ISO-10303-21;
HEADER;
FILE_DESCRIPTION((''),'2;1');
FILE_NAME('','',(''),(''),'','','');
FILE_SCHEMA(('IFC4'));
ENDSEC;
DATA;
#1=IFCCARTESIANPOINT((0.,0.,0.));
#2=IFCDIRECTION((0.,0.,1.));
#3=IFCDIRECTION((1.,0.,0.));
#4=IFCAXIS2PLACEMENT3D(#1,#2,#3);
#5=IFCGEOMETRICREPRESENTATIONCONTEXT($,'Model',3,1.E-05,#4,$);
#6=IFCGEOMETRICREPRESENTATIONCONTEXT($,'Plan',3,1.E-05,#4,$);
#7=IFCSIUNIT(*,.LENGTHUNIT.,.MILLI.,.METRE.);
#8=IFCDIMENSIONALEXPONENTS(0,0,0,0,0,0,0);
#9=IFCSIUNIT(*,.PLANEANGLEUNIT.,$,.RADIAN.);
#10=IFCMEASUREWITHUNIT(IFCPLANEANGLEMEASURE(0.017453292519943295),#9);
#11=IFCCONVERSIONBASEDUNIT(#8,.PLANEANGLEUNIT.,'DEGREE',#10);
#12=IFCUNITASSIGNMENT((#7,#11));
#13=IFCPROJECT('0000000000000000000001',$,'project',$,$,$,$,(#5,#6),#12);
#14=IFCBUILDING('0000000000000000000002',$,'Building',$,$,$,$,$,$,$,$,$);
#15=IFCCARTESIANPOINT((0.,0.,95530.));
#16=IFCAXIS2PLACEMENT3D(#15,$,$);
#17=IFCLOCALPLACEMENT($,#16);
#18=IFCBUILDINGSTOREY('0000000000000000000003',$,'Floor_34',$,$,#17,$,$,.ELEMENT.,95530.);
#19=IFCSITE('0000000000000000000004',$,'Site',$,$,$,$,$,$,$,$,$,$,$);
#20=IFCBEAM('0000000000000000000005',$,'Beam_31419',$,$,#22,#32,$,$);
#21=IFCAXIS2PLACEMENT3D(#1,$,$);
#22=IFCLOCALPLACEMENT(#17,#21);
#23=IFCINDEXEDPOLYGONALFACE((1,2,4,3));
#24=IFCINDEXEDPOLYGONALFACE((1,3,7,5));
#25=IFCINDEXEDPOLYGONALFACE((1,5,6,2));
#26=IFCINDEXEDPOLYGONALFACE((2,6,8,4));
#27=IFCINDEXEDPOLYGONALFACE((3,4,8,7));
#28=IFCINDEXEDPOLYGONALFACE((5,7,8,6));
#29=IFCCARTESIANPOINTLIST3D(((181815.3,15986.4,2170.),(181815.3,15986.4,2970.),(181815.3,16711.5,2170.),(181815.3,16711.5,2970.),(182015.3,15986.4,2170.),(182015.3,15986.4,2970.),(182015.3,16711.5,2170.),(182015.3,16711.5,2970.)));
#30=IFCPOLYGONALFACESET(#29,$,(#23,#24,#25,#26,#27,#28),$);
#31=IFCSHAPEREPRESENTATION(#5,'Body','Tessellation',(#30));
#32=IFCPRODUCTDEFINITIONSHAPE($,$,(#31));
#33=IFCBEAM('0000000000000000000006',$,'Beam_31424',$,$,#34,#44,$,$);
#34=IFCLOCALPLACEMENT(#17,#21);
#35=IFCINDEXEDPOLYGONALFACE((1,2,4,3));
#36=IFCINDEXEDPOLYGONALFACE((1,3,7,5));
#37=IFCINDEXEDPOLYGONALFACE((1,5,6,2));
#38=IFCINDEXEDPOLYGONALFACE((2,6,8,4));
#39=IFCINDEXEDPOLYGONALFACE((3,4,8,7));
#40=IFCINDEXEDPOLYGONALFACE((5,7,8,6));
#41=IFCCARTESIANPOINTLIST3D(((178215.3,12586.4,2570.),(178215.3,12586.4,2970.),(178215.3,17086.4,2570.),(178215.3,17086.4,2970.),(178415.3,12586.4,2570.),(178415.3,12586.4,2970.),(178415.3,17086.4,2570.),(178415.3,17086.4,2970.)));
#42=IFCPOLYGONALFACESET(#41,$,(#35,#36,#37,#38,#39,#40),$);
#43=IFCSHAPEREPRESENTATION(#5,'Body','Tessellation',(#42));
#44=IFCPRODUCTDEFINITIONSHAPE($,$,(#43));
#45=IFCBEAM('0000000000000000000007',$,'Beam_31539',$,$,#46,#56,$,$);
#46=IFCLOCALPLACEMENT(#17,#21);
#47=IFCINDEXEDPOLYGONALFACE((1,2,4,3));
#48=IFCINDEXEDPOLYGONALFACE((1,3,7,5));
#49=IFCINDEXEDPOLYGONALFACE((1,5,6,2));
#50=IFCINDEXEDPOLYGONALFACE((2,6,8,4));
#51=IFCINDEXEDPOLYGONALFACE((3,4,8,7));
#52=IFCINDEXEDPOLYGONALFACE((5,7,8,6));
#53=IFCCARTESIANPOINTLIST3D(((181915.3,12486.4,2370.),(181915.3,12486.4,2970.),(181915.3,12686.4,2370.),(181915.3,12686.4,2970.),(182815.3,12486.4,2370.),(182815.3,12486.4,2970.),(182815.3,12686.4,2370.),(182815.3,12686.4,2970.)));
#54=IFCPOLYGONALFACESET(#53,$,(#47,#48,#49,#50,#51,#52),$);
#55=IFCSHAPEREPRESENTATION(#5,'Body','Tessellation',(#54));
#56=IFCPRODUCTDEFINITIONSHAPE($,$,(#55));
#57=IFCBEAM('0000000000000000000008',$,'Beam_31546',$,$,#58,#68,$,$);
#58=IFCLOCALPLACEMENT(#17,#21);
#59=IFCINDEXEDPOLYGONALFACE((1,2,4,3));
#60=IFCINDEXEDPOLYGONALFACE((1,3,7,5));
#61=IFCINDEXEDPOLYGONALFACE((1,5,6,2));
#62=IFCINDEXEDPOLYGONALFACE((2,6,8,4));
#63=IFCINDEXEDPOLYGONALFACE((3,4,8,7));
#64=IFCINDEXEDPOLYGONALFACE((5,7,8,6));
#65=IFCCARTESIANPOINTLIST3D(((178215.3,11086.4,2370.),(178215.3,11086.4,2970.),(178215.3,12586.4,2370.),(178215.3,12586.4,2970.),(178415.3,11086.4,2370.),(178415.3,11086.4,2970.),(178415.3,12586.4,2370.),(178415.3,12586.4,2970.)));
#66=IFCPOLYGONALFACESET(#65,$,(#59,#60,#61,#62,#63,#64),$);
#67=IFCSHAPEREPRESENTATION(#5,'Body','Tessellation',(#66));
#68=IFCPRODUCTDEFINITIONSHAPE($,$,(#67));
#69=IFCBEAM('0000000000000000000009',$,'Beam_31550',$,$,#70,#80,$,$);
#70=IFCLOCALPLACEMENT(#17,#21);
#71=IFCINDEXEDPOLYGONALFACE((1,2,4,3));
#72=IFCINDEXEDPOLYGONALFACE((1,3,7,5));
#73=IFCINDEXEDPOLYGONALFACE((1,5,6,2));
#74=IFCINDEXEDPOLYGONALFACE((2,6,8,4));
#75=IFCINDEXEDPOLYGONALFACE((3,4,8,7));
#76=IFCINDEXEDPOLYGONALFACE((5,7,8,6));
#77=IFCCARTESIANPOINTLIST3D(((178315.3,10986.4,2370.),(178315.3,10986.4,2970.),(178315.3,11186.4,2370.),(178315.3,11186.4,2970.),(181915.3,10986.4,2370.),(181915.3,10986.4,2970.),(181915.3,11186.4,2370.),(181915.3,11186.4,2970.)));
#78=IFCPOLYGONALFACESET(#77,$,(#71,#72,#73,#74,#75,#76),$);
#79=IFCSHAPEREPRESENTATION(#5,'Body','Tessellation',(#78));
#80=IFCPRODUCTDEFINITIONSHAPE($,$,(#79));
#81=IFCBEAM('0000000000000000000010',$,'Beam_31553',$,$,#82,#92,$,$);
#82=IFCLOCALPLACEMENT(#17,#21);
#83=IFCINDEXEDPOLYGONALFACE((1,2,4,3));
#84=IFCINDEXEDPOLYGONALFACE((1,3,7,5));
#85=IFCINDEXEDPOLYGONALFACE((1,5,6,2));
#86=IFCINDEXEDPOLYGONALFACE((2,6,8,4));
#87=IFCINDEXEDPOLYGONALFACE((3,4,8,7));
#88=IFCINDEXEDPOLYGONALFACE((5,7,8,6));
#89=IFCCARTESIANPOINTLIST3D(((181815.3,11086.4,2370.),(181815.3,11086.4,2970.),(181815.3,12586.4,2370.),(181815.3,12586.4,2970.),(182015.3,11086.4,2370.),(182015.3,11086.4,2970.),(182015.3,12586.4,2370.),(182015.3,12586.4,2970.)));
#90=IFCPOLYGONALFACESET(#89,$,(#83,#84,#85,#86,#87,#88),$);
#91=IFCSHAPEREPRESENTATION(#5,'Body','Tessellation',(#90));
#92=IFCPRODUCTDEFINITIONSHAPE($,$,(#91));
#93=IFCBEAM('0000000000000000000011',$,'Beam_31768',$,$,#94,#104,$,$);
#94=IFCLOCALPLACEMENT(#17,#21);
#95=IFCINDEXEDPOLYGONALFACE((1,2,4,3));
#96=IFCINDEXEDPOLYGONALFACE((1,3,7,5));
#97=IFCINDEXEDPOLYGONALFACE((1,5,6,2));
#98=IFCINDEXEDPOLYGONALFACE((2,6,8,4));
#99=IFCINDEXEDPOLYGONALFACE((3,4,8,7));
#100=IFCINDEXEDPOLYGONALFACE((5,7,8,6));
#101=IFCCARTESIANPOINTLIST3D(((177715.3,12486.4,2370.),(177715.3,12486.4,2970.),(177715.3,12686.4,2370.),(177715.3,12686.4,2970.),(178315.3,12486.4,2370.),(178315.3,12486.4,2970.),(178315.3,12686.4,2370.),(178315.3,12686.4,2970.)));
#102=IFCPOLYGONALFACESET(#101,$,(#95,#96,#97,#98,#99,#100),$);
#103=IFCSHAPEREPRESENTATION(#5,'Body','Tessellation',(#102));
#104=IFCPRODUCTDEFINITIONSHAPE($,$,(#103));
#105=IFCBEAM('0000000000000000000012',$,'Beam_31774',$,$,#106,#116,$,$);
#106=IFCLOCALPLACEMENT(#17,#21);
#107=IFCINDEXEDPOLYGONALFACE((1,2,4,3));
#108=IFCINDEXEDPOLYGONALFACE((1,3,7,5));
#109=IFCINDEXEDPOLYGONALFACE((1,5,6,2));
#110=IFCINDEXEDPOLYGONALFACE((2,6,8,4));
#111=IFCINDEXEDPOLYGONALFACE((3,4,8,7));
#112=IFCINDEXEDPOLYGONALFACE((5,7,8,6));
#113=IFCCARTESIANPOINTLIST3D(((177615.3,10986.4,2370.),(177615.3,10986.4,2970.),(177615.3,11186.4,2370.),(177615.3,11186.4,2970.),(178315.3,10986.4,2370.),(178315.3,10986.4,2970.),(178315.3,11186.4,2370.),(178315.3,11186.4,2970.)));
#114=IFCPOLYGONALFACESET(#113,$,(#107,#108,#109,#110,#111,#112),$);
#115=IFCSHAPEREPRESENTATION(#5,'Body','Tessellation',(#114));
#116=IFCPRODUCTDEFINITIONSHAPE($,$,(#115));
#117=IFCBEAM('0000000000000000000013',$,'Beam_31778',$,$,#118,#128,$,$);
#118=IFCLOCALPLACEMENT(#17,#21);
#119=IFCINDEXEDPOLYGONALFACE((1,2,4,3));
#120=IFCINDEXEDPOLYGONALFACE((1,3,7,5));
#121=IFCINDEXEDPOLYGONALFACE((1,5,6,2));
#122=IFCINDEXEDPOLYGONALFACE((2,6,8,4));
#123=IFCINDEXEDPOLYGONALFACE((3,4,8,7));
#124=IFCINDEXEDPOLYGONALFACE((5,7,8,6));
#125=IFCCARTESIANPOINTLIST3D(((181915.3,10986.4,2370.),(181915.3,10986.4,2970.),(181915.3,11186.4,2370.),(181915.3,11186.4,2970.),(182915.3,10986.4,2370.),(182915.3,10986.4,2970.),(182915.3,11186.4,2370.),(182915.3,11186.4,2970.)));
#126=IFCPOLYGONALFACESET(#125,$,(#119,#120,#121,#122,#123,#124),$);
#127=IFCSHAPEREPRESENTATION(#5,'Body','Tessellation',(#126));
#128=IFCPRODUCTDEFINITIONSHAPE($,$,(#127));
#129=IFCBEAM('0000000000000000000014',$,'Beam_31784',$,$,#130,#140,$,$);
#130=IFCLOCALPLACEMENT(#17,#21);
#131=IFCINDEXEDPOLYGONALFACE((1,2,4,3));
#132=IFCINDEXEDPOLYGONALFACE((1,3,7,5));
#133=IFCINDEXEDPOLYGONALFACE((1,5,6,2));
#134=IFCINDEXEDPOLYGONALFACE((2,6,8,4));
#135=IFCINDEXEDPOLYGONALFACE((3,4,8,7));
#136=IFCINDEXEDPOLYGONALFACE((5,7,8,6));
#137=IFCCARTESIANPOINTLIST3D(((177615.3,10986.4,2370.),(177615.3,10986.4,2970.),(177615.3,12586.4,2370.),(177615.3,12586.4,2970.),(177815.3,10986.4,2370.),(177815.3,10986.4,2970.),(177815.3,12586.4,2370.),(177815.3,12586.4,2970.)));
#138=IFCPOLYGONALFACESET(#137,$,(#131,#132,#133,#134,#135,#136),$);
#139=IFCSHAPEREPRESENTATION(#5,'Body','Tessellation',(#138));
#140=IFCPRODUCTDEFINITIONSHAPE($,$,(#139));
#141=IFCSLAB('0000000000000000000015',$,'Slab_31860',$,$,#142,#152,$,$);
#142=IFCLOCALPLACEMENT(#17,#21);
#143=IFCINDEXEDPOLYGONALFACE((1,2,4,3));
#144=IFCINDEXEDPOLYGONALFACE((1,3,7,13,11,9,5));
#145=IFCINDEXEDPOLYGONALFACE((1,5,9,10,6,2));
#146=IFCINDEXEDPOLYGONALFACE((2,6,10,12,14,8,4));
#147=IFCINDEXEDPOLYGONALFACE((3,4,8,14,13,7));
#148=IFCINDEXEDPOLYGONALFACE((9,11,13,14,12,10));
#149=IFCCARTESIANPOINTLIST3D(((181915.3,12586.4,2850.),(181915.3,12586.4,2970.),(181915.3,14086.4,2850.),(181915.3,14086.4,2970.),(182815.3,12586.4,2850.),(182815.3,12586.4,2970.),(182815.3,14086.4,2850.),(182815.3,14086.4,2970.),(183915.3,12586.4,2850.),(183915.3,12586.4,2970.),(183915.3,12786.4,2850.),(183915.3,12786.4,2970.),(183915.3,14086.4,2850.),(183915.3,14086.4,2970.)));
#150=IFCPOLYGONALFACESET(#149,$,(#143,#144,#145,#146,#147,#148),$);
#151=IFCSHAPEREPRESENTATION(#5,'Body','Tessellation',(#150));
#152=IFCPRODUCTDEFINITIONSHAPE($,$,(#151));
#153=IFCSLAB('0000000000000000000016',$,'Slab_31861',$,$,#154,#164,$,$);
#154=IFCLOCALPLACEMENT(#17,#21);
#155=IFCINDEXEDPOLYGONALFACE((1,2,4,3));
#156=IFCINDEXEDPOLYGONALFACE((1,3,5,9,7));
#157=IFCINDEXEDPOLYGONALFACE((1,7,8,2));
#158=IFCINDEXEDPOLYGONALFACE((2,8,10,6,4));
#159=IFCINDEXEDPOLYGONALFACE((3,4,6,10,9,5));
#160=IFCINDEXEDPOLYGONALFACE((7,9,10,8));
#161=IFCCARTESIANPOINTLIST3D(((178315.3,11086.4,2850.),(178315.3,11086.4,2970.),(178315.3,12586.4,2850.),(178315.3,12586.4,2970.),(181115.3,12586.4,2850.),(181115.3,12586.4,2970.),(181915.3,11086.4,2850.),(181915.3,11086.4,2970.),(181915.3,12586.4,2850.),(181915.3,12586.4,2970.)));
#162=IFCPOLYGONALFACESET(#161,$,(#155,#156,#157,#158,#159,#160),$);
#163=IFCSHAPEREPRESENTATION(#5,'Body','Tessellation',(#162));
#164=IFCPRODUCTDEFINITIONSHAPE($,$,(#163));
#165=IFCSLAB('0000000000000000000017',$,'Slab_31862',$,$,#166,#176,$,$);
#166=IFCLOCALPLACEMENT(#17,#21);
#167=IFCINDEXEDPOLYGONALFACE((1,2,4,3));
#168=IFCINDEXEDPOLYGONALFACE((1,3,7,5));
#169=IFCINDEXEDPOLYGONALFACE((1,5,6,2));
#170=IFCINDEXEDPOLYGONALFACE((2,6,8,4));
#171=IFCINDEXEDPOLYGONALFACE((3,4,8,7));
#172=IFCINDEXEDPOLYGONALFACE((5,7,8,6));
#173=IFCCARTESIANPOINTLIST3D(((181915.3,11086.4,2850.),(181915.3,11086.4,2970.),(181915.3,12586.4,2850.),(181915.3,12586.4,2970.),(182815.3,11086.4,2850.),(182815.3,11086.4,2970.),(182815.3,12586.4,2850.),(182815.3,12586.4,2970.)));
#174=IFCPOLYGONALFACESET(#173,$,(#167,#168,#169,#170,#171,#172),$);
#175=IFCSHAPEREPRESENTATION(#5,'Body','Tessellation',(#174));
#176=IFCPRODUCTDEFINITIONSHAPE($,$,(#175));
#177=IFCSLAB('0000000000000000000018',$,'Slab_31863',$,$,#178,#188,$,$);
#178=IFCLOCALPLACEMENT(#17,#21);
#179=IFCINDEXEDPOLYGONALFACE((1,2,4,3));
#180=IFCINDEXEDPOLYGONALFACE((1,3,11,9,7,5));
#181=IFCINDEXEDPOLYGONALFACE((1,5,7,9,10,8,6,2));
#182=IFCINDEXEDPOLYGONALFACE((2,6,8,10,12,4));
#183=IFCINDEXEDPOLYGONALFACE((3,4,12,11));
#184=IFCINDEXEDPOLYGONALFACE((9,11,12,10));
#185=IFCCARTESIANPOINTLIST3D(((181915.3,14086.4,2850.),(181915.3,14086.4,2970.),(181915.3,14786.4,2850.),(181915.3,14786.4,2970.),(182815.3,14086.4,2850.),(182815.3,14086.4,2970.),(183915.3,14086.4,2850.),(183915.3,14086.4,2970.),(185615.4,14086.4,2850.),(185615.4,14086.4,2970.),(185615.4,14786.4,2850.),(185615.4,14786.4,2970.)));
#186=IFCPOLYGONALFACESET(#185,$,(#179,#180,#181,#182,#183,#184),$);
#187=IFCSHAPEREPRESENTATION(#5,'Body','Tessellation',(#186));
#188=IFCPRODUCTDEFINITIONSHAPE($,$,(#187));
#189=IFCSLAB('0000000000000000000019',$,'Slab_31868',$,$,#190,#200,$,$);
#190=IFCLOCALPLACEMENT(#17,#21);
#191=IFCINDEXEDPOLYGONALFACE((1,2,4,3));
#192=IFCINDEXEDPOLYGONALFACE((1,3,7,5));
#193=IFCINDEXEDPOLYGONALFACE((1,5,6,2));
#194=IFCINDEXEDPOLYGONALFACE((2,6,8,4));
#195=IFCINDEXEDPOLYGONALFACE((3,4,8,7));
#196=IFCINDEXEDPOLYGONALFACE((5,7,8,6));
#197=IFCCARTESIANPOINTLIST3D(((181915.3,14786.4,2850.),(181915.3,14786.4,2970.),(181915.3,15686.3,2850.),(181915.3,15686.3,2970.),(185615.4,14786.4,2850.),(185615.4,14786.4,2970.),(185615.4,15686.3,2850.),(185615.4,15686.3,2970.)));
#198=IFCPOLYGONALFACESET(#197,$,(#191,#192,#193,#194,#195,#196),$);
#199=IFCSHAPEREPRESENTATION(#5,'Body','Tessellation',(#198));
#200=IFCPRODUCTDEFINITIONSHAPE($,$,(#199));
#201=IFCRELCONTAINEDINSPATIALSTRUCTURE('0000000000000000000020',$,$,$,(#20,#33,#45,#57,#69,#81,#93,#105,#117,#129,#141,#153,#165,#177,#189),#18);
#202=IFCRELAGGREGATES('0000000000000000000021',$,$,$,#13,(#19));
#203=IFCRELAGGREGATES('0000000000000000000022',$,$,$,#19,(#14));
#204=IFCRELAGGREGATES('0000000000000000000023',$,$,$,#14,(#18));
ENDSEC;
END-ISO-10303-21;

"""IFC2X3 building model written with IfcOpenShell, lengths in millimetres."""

from ifc_helpers import new_model, entity, si_unit, converted_unit, frame, origin_with_axes, origin_2d, place, context, project, spatial, polyline, rectangle, outline, extrude, element, save


model = new_model("IFC2X3")

# Units and contexts
model_context = context("Model", 3, precision=1e-05, world=origin_with_axes())
plan_context = context("Plan", 3, precision=1e-05, world=origin_with_axes())
ifc_project = project(units=[si_unit("LENGTHUNIT", "METRE", prefix="MILLI"), converted_unit("PLANEANGLEUNIT", "DEGREE", entity("IfcPlaneAngleMeasure", 0.017453292519943295), si_unit("PLANEANGLEUNIT", "RADIAN"), dimensions=[0, 0, 0, 0, 0, 0, 0])], contexts=[model_context, plan_context])

# Site, building, storey
site = spatial("IfcSite", under=ifc_project, Name="Site")
building = spatial("IfcBuilding", under=site, Name="Building")
storey_placement = place(None, frame((0.0, 0.0, 95530.0)))
storey = spatial("IfcBuildingStorey", under=building, at=storey_placement, Name="Floor_34", CompositionType="ELEMENT", Elevation=95530.0)

# Beams
beam_1_placement = place(storey_placement, frame((181915.3, 15986.4, 2570.0), z_axis=(0.000545, 725.122518, 0.0), x_axis=(725.122518, -0.000545, 0.0)))
element("IfcBeam", 1, at=beam_1_placement, inside=storey, Name="Beam_31419", context=model_context, shape_type="SweptSolid", body=[
    extrude(rectangle(XDim=200.0, YDim=800.0, at=origin_2d()), origin_with_axes(), (0.0, 0.0, 1.0), 725.1),
])
beam_2_placement = place(storey_placement, frame((178315.3, 12586.4, 2770.0), z_axis=(-0.000334, 4500.030689, 0.0), x_axis=(4500.030689, 0.000334, 0.0)))
element("IfcBeam", 2, at=beam_2_placement, inside=storey, Name="Beam_31424", context=model_context, shape_type="SweptSolid", body=[
    extrude(rectangle(XDim=200.0, YDim=400.0, at=origin_2d()), origin_with_axes(), (0.0, 0.0, 1.0), 4500.0),
])
beam_3_placement = place(storey_placement, frame((181915.3, 12586.4, 2670.0), z_axis=(900.0, 0.0, 0.0), x_axis=(0.0, -900.0, 0.0)))
element("IfcBeam", 3, at=beam_3_placement, inside=storey, Name="Beam_31539", context=model_context, shape_type="SweptSolid", body=[
    extrude(rectangle(XDim=200.0, YDim=600.0, at=origin_2d()), origin_with_axes(), (0.0, 0.0, 1.0), 900.0),
])
beam_4_placement = place(storey_placement, frame((178315.3, 11086.4, 2670.0), z_axis=(0.0, 1500.0, 0.0), x_axis=(1500.0, 0.0, 0.0)))
element("IfcBeam", 4, at=beam_4_placement, inside=storey, Name="Beam_31546", context=model_context, shape_type="SweptSolid", body=[
    extrude(rectangle(XDim=200.0, YDim=600.0, at=origin_2d()), origin_with_axes(), (0.0, 0.0, 1.0), 1500.0),
])
beam_5_placement = place(storey_placement, frame((178315.3, 11086.4, 2670.0), z_axis=(3600.00001, 0.0, 0.0), x_axis=(0.0, -3600.00001, 0.0)))
element("IfcBeam", 5, at=beam_5_placement, inside=storey, Name="Beam_31550", context=model_context, shape_type="SweptSolid", body=[
    extrude(rectangle(XDim=200.0, YDim=600.0, at=origin_2d()), origin_with_axes(), (0.0, 0.0, 1.0), 3600.0),
])
beam_6_placement = place(storey_placement, frame((181915.3, 11086.4, 2670.0), z_axis=(0.0, 1500.0, 0.0), x_axis=(1500.0, 0.0, 0.0)))
element("IfcBeam", 6, at=beam_6_placement, inside=storey, Name="Beam_31553", context=model_context, shape_type="SweptSolid", body=[
    extrude(rectangle(XDim=200.0, YDim=600.0, at=origin_2d()), origin_with_axes(), (0.0, 0.0, 1.0), 1500.0),
])
beam_7_placement = place(storey_placement, frame((177715.3, 12586.4, 2670.0), z_axis=(600.0, 0.0, 0.0), x_axis=(0.0, -600.0, 0.0)))
element("IfcBeam", 7, at=beam_7_placement, inside=storey, Name="Beam_31768", context=model_context, shape_type="SweptSolid", body=[
    extrude(rectangle(XDim=200.0, YDim=600.0, at=origin_2d()), origin_with_axes(), (0.0, 0.0, 1.0), 600.0),
])
beam_8_placement = place(storey_placement, frame((177615.3, 11086.4, 2670.0), z_axis=(700.0, 0.0, 0.0), x_axis=(0.0, -700.0, 0.0)))
element("IfcBeam", 8, at=beam_8_placement, inside=storey, Name="Beam_31774", context=model_context, shape_type="SweptSolid", body=[
    extrude(rectangle(XDim=200.0, YDim=600.0, at=origin_2d()), origin_with_axes(), (0.0, 0.0, 1.0), 700.0),
])
beam_9_placement = place(storey_placement, frame((181915.3, 11086.4, 2670.0), z_axis=(1000.0, 0.0, 0.0), x_axis=(0.0, -1000.0, 0.0)))
element("IfcBeam", 9, at=beam_9_placement, inside=storey, Name="Beam_31778", context=model_context, shape_type="SweptSolid", body=[
    extrude(rectangle(XDim=200.0, YDim=600.0, at=origin_2d()), origin_with_axes(), (0.0, 0.0, 1.0), 1000.0),
])
beam_10_placement = place(storey_placement, frame((177715.3, 10986.4, 2670.0), z_axis=(0.0, 1600.0, 0.0), x_axis=(1600.0, 0.0, 0.0)))
element("IfcBeam", 10, at=beam_10_placement, inside=storey, Name="Beam_31784", context=model_context, shape_type="SweptSolid", body=[
    extrude(rectangle(XDim=200.0, YDim=600.0, at=origin_2d()), origin_with_axes(), (0.0, 0.0, 1.0), 1600.0),
])

# Slabs
slab_1_placement = place(storey_placement, frame((181915.3, 14086.4, 2850.0), z_axis=(0.0, 0.0, 1.0), x_axis=(0.0, -1500.0, 0.0)))
element("IfcSlab", 11, at=slab_1_placement, inside=storey, Name="Slab_31860", context=model_context, shape_type="SweptSolid", body=[
    extrude(outline(polyline([(0.0, 0.0), (1500.0, 0.0), (1500.0, 900.0), (1500.0, 2000.0), (1300.0, 2000.0), (0.0, 2000.0), (0.0, 900.0)])), origin_with_axes(), (0.0, 0.0, 1.0), 120.0),
])
slab_2_placement = place(storey_placement, frame((178315.3, 12586.4, 2850.0), z_axis=(0.0, 0.0, 1.0), x_axis=(0.0, -1500.0, 0.0)))
element("IfcSlab", 12, at=slab_2_placement, inside=storey, Name="Slab_31861", context=model_context, shape_type="SweptSolid", body=[
    extrude(outline(polyline([(0.0, 0.0), (1500.0, 0.0), (1500.0, 3600.0), (0.0, 3600.0), (0.0, 2800.0)])), origin_with_axes(), (0.0, 0.0, 1.0), 120.0),
])
slab_3_placement = place(storey_placement, frame((181915.3, 12586.4, 2850.0), z_axis=(0.0, 0.0, 1.0), x_axis=(0.0, -1500.0, 0.0)))
element("IfcSlab", 13, at=slab_3_placement, inside=storey, Name="Slab_31862", context=model_context, shape_type="SweptSolid", body=[
    extrude(outline(polyline([(0.0, 0.0), (1500.0, 0.0), (1500.0, 900.0), (0.0, 900.0)])), origin_with_axes(), (0.0, 0.0, 1.0), 120.0),
])
slab_4_placement = place(storey_placement, frame((181915.3, 14786.4, 2850.0), z_axis=(0.0, 0.0, 1.0), x_axis=(0.0, -700.0, 0.0)))
element("IfcSlab", 14, at=slab_4_placement, inside=storey, Name="Slab_31863", context=model_context, shape_type="SweptSolid", body=[
    extrude(outline(polyline([(0.0, 0.0), (700.0, 0.0), (700.0, 900.0), (700.0, 2000.0), (700.0, 3700.1), (-0.1, 3700.0)])), origin_with_axes(), (0.0, 0.0, 1.0), 120.0),
])
slab_5_placement = place(storey_placement, frame((181915.3, 15686.3, 2850.0), z_axis=(0.0, 0.0, 1.0), x_axis=(0.008, -899.894, 0.0)))
element("IfcSlab", 15, at=slab_5_placement, inside=storey, Name="Slab_31868", context=model_context, shape_type="SweptSolid", body=[
    extrude(outline(polyline([(0.0, 0.0), (899.9, 0.0), (899.9, 3700.0), (0.0, 3700.0)])), origin_with_axes(), (0.0, 0.0, 1.0), 120.0),
])

save(model, "model.ifc")
